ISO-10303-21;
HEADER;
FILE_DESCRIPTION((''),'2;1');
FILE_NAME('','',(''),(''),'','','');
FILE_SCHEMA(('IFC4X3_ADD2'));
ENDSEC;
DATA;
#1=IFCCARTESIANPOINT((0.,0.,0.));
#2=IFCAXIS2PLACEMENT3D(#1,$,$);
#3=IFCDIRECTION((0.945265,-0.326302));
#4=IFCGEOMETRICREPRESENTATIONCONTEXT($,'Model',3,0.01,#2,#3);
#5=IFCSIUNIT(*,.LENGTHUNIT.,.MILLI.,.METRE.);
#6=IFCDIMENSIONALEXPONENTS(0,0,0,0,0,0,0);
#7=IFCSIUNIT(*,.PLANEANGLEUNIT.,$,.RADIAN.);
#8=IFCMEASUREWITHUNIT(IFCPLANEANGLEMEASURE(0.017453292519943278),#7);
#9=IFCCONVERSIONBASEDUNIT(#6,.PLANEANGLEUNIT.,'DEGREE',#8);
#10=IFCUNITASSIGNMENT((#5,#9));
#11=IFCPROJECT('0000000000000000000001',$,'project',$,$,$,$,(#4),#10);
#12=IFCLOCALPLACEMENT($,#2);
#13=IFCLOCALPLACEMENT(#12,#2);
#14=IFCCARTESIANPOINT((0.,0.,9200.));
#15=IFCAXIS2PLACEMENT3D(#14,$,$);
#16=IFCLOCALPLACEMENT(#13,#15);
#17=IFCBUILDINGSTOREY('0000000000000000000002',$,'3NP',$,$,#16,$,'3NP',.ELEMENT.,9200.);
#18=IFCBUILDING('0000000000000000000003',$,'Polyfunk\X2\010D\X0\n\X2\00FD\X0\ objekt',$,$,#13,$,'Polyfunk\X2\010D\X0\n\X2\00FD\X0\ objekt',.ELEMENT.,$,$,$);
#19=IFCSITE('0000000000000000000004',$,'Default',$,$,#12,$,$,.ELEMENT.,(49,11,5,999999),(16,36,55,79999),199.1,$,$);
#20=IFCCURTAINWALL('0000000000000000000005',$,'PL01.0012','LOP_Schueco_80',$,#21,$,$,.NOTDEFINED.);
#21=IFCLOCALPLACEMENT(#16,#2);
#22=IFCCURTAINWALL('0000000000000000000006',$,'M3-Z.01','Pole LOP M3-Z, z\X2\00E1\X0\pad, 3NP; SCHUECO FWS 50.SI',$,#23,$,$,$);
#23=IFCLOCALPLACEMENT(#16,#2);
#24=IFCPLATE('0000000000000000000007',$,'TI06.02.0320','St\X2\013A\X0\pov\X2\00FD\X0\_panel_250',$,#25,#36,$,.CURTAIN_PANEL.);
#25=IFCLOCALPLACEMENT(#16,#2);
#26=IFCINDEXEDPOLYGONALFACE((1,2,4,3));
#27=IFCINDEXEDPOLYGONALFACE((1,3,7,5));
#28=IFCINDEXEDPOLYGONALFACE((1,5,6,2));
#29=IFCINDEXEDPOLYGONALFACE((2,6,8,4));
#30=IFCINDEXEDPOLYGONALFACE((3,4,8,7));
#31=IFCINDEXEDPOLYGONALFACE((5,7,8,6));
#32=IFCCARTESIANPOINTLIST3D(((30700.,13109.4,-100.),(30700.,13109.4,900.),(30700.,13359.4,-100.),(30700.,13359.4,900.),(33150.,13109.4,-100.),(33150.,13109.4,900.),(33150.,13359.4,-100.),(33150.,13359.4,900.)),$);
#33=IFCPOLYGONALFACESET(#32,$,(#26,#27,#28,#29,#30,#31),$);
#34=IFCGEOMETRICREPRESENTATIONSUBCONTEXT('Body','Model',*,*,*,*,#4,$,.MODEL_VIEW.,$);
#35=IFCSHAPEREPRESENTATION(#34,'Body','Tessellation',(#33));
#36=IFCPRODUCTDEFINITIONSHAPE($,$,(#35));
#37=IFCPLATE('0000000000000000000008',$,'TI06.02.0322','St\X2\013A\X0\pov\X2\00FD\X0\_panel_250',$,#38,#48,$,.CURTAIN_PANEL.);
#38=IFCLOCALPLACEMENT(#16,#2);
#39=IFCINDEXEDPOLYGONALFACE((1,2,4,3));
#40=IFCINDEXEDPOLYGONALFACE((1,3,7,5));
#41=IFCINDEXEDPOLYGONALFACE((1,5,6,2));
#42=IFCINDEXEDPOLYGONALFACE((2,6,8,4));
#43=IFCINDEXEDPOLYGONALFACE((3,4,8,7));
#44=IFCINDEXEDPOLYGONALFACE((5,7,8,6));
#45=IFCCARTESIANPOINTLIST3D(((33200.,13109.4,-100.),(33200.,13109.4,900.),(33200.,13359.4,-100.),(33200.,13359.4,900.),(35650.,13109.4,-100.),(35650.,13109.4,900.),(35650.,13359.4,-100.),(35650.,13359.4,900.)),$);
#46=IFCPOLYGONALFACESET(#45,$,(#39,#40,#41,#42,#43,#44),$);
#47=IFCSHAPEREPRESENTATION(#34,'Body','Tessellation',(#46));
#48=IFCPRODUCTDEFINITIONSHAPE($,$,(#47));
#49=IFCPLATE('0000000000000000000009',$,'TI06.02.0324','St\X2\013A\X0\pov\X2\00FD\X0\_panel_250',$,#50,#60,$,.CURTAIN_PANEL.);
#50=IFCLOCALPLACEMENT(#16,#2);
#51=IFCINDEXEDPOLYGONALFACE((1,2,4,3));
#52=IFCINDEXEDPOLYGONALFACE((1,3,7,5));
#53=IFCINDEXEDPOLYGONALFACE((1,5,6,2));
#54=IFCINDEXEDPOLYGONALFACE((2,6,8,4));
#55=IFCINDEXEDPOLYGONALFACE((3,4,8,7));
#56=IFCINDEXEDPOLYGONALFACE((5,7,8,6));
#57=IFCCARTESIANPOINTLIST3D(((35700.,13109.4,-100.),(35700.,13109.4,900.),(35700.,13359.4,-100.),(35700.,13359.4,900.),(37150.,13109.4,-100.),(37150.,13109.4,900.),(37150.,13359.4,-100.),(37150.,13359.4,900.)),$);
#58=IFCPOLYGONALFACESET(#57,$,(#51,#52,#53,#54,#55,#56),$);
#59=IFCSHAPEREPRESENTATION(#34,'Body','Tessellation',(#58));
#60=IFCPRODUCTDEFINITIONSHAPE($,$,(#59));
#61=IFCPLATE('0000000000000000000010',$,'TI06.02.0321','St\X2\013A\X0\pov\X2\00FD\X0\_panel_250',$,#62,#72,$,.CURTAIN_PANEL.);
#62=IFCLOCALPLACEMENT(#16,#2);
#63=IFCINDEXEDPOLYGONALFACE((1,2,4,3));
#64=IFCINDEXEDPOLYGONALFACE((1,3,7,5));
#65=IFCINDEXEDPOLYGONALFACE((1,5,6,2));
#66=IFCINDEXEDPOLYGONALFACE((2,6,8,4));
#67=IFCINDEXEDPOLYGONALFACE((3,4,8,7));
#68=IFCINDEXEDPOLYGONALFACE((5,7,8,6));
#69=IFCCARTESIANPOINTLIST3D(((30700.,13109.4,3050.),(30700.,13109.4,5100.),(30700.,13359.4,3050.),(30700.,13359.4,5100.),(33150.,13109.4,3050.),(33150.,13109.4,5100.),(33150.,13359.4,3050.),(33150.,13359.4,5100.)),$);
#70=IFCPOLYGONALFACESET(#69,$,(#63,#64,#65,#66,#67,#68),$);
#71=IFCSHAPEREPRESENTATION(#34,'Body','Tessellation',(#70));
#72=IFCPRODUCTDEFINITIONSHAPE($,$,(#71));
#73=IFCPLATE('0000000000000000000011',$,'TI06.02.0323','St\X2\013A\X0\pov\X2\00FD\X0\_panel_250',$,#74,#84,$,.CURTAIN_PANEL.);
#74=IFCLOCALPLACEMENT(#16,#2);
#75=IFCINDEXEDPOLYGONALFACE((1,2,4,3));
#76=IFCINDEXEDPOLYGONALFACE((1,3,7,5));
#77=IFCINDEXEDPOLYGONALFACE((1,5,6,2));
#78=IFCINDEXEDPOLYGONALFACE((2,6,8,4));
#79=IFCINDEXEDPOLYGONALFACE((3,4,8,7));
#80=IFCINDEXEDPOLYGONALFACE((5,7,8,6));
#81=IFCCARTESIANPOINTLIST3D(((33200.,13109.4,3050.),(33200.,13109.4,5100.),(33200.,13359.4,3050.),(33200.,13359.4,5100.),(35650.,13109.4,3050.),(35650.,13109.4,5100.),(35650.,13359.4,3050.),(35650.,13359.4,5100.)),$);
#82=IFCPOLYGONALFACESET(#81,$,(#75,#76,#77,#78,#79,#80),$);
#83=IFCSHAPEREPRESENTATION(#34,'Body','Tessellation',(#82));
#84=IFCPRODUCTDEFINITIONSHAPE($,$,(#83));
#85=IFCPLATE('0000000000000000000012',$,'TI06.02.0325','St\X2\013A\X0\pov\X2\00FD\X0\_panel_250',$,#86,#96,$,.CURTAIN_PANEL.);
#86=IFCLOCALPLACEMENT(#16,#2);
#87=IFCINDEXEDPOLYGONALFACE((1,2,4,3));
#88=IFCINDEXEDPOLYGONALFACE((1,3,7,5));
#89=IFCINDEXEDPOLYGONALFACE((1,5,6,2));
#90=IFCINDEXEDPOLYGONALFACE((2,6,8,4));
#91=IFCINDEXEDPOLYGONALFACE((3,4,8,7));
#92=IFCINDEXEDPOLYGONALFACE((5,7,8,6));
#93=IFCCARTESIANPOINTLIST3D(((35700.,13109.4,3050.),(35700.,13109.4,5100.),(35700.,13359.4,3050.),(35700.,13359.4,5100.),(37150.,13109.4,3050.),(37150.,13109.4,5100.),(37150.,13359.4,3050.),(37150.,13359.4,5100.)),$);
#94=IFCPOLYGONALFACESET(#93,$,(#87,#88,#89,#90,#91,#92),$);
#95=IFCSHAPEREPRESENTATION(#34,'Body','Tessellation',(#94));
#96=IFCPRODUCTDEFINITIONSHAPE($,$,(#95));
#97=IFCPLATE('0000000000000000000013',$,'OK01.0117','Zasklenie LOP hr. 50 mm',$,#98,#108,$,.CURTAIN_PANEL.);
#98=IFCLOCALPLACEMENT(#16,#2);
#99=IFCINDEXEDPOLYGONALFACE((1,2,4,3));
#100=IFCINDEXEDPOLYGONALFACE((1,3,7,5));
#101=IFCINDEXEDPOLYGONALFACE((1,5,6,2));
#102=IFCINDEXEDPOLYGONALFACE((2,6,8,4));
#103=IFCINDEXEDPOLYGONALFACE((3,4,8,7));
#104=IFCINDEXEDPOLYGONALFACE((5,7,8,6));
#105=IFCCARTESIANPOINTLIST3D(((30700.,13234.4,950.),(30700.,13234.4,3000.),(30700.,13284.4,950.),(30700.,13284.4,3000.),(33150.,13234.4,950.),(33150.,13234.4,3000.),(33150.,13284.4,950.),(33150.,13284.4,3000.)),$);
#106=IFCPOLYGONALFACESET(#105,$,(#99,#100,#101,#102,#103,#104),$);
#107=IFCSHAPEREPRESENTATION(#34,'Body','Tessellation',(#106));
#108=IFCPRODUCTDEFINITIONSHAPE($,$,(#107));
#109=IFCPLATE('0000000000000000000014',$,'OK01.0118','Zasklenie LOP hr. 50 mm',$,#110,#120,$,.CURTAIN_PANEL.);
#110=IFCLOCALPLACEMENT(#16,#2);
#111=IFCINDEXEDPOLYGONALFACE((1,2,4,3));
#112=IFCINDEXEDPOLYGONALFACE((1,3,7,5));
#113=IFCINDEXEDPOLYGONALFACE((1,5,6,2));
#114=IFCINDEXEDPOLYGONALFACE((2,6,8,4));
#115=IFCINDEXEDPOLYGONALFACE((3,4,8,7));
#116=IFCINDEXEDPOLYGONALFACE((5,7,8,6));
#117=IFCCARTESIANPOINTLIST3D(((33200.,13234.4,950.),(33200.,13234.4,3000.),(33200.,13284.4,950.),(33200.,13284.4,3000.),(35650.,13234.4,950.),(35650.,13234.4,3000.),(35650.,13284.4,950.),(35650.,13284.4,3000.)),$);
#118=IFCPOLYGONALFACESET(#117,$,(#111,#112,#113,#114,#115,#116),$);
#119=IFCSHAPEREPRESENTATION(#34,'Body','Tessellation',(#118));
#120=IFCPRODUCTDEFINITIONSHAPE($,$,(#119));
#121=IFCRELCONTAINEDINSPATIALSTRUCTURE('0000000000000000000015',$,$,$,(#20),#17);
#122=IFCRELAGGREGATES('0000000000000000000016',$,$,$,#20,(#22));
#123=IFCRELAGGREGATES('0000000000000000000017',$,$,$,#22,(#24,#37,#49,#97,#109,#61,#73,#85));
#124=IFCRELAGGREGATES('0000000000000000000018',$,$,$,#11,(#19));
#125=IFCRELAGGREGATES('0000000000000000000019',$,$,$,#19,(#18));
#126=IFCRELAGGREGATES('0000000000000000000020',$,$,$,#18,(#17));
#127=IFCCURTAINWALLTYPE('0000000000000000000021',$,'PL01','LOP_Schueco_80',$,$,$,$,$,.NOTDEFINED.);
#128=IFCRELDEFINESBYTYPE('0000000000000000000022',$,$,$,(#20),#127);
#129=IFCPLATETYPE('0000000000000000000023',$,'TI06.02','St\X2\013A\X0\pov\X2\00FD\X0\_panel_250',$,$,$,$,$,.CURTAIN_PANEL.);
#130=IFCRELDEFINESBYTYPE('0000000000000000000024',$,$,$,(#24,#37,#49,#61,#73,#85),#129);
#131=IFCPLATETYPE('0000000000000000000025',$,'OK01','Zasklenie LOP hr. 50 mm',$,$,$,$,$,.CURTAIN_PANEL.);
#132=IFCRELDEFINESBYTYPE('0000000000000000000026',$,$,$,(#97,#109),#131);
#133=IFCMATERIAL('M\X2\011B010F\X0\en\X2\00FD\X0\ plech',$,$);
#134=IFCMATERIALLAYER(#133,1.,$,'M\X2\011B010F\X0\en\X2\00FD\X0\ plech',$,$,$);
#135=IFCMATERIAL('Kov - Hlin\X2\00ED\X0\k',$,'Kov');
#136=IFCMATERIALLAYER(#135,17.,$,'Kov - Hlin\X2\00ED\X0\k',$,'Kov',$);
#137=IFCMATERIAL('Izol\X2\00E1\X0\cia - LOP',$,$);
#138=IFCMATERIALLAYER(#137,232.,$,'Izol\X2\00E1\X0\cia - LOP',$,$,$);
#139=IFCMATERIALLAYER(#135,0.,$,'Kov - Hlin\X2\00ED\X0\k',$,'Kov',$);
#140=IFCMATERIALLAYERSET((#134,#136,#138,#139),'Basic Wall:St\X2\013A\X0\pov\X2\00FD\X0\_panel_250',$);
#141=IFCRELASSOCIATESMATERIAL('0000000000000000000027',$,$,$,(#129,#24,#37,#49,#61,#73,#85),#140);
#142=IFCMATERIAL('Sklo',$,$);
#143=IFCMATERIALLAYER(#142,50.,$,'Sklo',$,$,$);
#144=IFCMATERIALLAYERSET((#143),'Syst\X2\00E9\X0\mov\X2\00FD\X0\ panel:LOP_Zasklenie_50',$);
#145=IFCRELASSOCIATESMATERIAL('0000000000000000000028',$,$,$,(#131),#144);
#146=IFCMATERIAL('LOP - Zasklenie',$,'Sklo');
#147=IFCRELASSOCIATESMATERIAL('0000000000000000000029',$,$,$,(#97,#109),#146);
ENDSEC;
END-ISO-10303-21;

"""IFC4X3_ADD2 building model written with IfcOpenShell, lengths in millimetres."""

from ifc_helpers import new_model, entity, si_unit, converted_unit, direction, frame, frame_2d, origin, origin_2d_with_axis, place, context, subcontext, project, spatial, rectangle, extrude, source, transform, mapped, material, layer, layer_set, layer_usage, type_object, type_shapes, element, aggregate, save


model = new_model("IFC4X3_ADD2")

# Units and contexts
model_context = context("Model", 3, precision=0.01, world=origin(), true_north=direction((0.945265, -0.326302)))
body_context = subcontext(model_context, "Body", "Model", "MODEL_VIEW")
ifc_project = project(units=[si_unit("LENGTHUNIT", "METRE", prefix="MILLI"), converted_unit("PLANEANGLEUNIT", "DEGREE", entity("IfcPlaneAngleMeasure", 0.017453292519943278), si_unit("PLANEANGLEUNIT", "RADIAN"), dimensions=[0, 0, 0, 0, 0, 0, 0])], contexts=[model_context])

# Site, building, storey
site_placement = place(None, origin())
site = spatial("IfcSite", under=ifc_project, at=site_placement, Name="Default", CompositionType="ELEMENT", RefLatitude=(49, 11, 5, 999999), RefLongitude=(16, 36, 55, 79999), RefElevation=199.1)
building_placement = place(site_placement, origin())
building = spatial("IfcBuilding", under=site, at=building_placement, Name="Polyfunkčný objekt", LongName="Polyfunkčný objekt", CompositionType="ELEMENT")
storey_placement = place(building_placement, frame((0.0, 0.0, 9200.0)))
storey = spatial("IfcBuildingStorey", under=building, at=storey_placement, Name="3NP", LongName="3NP", CompositionType="ELEMENT", Elevation=9200.0)

# Curtain walls, plates
curtain_wall_type = type_object("IfcCurtainWallType", Name="PL01", Description="LOP_Schueco_80", PredefinedType="NOTDEFINED")
curtain_wall_1_placement = place(storey_placement, frame((0.0, 0.0, -9200.0)))
curtain_wall_1 = element("IfcCurtainWall", 1, at=curtain_wall_1_placement, inside=storey, type_object=curtain_wall_type, Name="PL01.0012", Description="LOP_Schueco_80", PredefinedType="NOTDEFINED")
curtain_wall_2 = element("IfcCurtainWall", 2, Name="M3-Z.01", Description="Pole LOP M3-Z, západ, 3NP; SCHUECO FWS 50.SI")
aggregate(curtain_wall_1, [curtain_wall_2])
ifc_material_1 = material(Name="Měďený plech")
ifc_layer_1 = layer(ifc_material_1, 1.0, Name="Měďený plech")
ifc_material_2 = material(Name="Kov - Hliník", Category="Kov")
ifc_layer_2 = layer(ifc_material_2, 17.0, Name="Kov - Hliník", Category="Kov")
ifc_material_3 = material(Name="Izolácia - LOP")
ifc_layer_3 = layer(ifc_material_3, 232.0, Name="Izolácia - LOP")
ifc_layer_4 = layer(ifc_material_2, 0.0, Name="Kov - Hliník", Category="Kov")
ifc_layer_set_1 = layer_set([ifc_layer_1, ifc_layer_2, ifc_layer_3, ifc_layer_4], Name="Basic Wall:Stĺpový_panel_250")
ifc_layer_usage_1 = layer_usage(ifc_layer_set_1, "AXIS2", "NEGATIVE", 125.0)
plate_type_1 = type_object("IfcPlateType", Name="TI06.02", Description="Stĺpový_panel_250", PredefinedType="CURTAIN_PANEL", material=ifc_layer_set_1)
plate_1_placement = place(storey_placement, frame((30700.0, 13234.4, -100.0)))
plate_1 = element("IfcPlate", 3, at=plate_1_placement, type_object=plate_type_1, material=ifc_layer_usage_1, Name="TI06.02.0320", Description="Stĺpový_panel_250", PredefinedType="CURTAIN_PANEL", context=body_context, shape_type="SweptSolid", body=[
    extrude(rectangle(XDim=250.0, YDim=2450.0, at=frame_2d((0.0, 0.0), x_axis=(1.0, 0.0))), frame((1225.0, 0.0, 0.0), z_axis=(0.0, 0.0, 1.0), x_axis=(0.0, 1.0, 0.0)), (0.0, 0.0, 1.0), 1000.0),
])
ifc_layer_usage_2 = layer_usage(ifc_layer_set_1, "AXIS2", "NEGATIVE", 125.0)
plate_2_placement = place(storey_placement, frame((33200.0, 13234.4, -100.0)))
plate_2 = element("IfcPlate", 4, at=plate_2_placement, type_object=plate_type_1, material=ifc_layer_usage_2, Name="TI06.02.0322", Description="Stĺpový_panel_250", PredefinedType="CURTAIN_PANEL", context=body_context, shape_type="SweptSolid", body=[
    extrude(rectangle(XDim=250.0, YDim=2450.0, at=frame_2d((0.0, 0.0), x_axis=(1.0, 0.0))), frame((1225.0, 0.0, 0.0), z_axis=(0.0, 0.0, 1.0), x_axis=(0.0, 1.0, 0.0)), (0.0, 0.0, 1.0), 1000.0),
])
ifc_layer_usage_3 = layer_usage(ifc_layer_set_1, "AXIS2", "NEGATIVE", 125.0)
plate_3_placement = place(storey_placement, frame((35700.0, 13234.4, -100.0)))
plate_3 = element("IfcPlate", 5, at=plate_3_placement, type_object=plate_type_1, material=ifc_layer_usage_3, Name="TI06.02.0324", Description="Stĺpový_panel_250", PredefinedType="CURTAIN_PANEL", context=body_context, shape_type="SweptSolid", body=[
    extrude(rectangle(XDim=250.0, YDim=1450.0, at=origin_2d_with_axis()), frame((725.0, 0.0, 0.0), z_axis=(0.0, 0.0, 1.0), x_axis=(0.0, 1.0, 0.0)), (0.0, 0.0, 1.0), 1000.0),
])
ifc_layer_usage_4 = layer_usage(ifc_layer_set_1, "AXIS2", "NEGATIVE", 125.0)
plate_4_placement = place(storey_placement, frame((30700.0, 13234.4, 3050.0)))
plate_4 = element("IfcPlate", 6, at=plate_4_placement, type_object=plate_type_1, material=ifc_layer_usage_4, Name="TI06.02.0321", Description="Stĺpový_panel_250", PredefinedType="CURTAIN_PANEL", context=body_context, shape_type="SweptSolid", body=[
    extrude(rectangle(XDim=250.0, YDim=2450.0, at=frame_2d((0.0, 0.0), x_axis=(1.0, 0.0))), frame((1225.0, 0.0, 0.0), z_axis=(0.0, 0.0, 1.0), x_axis=(0.0, 1.0, 0.0)), (0.0, 0.0, 1.0), 2050.0),
])
ifc_layer_usage_5 = layer_usage(ifc_layer_set_1, "AXIS2", "NEGATIVE", 125.0)
plate_5_placement = place(storey_placement, frame((33200.0, 13234.4, 3050.0)))
plate_5 = element("IfcPlate", 7, at=plate_5_placement, type_object=plate_type_1, material=ifc_layer_usage_5, Name="TI06.02.0323", Description="Stĺpový_panel_250", PredefinedType="CURTAIN_PANEL", context=body_context, shape_type="SweptSolid", body=[
    extrude(rectangle(XDim=250.0, YDim=2450.0, at=frame_2d((0.0, 0.0), x_axis=(1.0, 0.0))), frame((1225.0, 0.0, 0.0), z_axis=(0.0, 0.0, 1.0), x_axis=(0.0, 1.0, 0.0)), (0.0, 0.0, 1.0), 2050.0),
])
ifc_layer_usage_6 = layer_usage(ifc_layer_set_1, "AXIS2", "NEGATIVE", 125.0)
plate_6_placement = place(storey_placement, frame((35700.0, 13234.4, 3050.0)))
plate_6 = element("IfcPlate", 8, at=plate_6_placement, type_object=plate_type_1, material=ifc_layer_usage_6, Name="TI06.02.0325", Description="Stĺpový_panel_250", PredefinedType="CURTAIN_PANEL", context=body_context, shape_type="SweptSolid", body=[
    extrude(rectangle(XDim=250.0, YDim=1450.0, at=origin_2d_with_axis()), frame((725.0, 0.0, 0.0), z_axis=(0.0, 0.0, 1.0), x_axis=(0.0, 1.0, 0.0)), (0.0, 0.0, 1.0), 2050.0),
])
ifc_material_4 = material(Name="LOP - Zasklenie", Category="Sklo")
ifc_material_5 = material(Name="Sklo")
ifc_layer_5 = layer(ifc_material_5, 50.0, Name="Sklo")
ifc_layer_set_2 = layer_set([ifc_layer_5], Name="Systémový panel:LOP_Zasklenie_50")
plate_type_2 = type_object("IfcPlateType", Name="OK01", Description="Zasklenie LOP hr. 50 mm", PredefinedType="CURTAIN_PANEL", material=ifc_layer_set_2)
shared_shape_1 = source(origin(), body_context, "Body", "SweptSolid", [
    extrude(rectangle(XDim=50.0, YDim=2450.0, at=origin_2d_with_axis()), frame((0.0, 25.0, 0.0), z_axis=(0.0, 0.0, 1.0), x_axis=(0.0, 1.0, 0.0)), (0.0, 0.0, 1.0), 2050.0),
])
type_shapes(plate_type_2, [shared_shape_1])
plate_7_placement = place(curtain_wall_1_placement, frame((31925.0, 13234.4, 10150.0)))
plate_7 = element("IfcPlate", 9, at=plate_7_placement, type_object=plate_type_2, material=ifc_material_4, Name="OK01.0117", Description="Zasklenie LOP hr. 50 mm", PredefinedType="CURTAIN_PANEL", context=body_context, shape_type="MappedRepresentation", body=[
    mapped(shared_shape_1, transform((0.0, 0.0, 0.0), scale=1.0)),
])
plate_8_placement = place(curtain_wall_1_placement, frame((34425.0, 13234.4, 10150.0)))
plate_8 = element("IfcPlate", 10, at=plate_8_placement, type_object=plate_type_2, material=ifc_material_4, Name="OK01.0118", Description="Zasklenie LOP hr. 50 mm", PredefinedType="CURTAIN_PANEL", context=body_context, shape_type="MappedRepresentation", body=[
    mapped(shared_shape_1, transform((0.0, 0.0, 0.0), scale=1.0)),
])
aggregate(curtain_wall_2, [plate_1, plate_2, plate_3, plate_7, plate_8, plate_4, plate_5, plate_6])

save(model, "model.ifc")
